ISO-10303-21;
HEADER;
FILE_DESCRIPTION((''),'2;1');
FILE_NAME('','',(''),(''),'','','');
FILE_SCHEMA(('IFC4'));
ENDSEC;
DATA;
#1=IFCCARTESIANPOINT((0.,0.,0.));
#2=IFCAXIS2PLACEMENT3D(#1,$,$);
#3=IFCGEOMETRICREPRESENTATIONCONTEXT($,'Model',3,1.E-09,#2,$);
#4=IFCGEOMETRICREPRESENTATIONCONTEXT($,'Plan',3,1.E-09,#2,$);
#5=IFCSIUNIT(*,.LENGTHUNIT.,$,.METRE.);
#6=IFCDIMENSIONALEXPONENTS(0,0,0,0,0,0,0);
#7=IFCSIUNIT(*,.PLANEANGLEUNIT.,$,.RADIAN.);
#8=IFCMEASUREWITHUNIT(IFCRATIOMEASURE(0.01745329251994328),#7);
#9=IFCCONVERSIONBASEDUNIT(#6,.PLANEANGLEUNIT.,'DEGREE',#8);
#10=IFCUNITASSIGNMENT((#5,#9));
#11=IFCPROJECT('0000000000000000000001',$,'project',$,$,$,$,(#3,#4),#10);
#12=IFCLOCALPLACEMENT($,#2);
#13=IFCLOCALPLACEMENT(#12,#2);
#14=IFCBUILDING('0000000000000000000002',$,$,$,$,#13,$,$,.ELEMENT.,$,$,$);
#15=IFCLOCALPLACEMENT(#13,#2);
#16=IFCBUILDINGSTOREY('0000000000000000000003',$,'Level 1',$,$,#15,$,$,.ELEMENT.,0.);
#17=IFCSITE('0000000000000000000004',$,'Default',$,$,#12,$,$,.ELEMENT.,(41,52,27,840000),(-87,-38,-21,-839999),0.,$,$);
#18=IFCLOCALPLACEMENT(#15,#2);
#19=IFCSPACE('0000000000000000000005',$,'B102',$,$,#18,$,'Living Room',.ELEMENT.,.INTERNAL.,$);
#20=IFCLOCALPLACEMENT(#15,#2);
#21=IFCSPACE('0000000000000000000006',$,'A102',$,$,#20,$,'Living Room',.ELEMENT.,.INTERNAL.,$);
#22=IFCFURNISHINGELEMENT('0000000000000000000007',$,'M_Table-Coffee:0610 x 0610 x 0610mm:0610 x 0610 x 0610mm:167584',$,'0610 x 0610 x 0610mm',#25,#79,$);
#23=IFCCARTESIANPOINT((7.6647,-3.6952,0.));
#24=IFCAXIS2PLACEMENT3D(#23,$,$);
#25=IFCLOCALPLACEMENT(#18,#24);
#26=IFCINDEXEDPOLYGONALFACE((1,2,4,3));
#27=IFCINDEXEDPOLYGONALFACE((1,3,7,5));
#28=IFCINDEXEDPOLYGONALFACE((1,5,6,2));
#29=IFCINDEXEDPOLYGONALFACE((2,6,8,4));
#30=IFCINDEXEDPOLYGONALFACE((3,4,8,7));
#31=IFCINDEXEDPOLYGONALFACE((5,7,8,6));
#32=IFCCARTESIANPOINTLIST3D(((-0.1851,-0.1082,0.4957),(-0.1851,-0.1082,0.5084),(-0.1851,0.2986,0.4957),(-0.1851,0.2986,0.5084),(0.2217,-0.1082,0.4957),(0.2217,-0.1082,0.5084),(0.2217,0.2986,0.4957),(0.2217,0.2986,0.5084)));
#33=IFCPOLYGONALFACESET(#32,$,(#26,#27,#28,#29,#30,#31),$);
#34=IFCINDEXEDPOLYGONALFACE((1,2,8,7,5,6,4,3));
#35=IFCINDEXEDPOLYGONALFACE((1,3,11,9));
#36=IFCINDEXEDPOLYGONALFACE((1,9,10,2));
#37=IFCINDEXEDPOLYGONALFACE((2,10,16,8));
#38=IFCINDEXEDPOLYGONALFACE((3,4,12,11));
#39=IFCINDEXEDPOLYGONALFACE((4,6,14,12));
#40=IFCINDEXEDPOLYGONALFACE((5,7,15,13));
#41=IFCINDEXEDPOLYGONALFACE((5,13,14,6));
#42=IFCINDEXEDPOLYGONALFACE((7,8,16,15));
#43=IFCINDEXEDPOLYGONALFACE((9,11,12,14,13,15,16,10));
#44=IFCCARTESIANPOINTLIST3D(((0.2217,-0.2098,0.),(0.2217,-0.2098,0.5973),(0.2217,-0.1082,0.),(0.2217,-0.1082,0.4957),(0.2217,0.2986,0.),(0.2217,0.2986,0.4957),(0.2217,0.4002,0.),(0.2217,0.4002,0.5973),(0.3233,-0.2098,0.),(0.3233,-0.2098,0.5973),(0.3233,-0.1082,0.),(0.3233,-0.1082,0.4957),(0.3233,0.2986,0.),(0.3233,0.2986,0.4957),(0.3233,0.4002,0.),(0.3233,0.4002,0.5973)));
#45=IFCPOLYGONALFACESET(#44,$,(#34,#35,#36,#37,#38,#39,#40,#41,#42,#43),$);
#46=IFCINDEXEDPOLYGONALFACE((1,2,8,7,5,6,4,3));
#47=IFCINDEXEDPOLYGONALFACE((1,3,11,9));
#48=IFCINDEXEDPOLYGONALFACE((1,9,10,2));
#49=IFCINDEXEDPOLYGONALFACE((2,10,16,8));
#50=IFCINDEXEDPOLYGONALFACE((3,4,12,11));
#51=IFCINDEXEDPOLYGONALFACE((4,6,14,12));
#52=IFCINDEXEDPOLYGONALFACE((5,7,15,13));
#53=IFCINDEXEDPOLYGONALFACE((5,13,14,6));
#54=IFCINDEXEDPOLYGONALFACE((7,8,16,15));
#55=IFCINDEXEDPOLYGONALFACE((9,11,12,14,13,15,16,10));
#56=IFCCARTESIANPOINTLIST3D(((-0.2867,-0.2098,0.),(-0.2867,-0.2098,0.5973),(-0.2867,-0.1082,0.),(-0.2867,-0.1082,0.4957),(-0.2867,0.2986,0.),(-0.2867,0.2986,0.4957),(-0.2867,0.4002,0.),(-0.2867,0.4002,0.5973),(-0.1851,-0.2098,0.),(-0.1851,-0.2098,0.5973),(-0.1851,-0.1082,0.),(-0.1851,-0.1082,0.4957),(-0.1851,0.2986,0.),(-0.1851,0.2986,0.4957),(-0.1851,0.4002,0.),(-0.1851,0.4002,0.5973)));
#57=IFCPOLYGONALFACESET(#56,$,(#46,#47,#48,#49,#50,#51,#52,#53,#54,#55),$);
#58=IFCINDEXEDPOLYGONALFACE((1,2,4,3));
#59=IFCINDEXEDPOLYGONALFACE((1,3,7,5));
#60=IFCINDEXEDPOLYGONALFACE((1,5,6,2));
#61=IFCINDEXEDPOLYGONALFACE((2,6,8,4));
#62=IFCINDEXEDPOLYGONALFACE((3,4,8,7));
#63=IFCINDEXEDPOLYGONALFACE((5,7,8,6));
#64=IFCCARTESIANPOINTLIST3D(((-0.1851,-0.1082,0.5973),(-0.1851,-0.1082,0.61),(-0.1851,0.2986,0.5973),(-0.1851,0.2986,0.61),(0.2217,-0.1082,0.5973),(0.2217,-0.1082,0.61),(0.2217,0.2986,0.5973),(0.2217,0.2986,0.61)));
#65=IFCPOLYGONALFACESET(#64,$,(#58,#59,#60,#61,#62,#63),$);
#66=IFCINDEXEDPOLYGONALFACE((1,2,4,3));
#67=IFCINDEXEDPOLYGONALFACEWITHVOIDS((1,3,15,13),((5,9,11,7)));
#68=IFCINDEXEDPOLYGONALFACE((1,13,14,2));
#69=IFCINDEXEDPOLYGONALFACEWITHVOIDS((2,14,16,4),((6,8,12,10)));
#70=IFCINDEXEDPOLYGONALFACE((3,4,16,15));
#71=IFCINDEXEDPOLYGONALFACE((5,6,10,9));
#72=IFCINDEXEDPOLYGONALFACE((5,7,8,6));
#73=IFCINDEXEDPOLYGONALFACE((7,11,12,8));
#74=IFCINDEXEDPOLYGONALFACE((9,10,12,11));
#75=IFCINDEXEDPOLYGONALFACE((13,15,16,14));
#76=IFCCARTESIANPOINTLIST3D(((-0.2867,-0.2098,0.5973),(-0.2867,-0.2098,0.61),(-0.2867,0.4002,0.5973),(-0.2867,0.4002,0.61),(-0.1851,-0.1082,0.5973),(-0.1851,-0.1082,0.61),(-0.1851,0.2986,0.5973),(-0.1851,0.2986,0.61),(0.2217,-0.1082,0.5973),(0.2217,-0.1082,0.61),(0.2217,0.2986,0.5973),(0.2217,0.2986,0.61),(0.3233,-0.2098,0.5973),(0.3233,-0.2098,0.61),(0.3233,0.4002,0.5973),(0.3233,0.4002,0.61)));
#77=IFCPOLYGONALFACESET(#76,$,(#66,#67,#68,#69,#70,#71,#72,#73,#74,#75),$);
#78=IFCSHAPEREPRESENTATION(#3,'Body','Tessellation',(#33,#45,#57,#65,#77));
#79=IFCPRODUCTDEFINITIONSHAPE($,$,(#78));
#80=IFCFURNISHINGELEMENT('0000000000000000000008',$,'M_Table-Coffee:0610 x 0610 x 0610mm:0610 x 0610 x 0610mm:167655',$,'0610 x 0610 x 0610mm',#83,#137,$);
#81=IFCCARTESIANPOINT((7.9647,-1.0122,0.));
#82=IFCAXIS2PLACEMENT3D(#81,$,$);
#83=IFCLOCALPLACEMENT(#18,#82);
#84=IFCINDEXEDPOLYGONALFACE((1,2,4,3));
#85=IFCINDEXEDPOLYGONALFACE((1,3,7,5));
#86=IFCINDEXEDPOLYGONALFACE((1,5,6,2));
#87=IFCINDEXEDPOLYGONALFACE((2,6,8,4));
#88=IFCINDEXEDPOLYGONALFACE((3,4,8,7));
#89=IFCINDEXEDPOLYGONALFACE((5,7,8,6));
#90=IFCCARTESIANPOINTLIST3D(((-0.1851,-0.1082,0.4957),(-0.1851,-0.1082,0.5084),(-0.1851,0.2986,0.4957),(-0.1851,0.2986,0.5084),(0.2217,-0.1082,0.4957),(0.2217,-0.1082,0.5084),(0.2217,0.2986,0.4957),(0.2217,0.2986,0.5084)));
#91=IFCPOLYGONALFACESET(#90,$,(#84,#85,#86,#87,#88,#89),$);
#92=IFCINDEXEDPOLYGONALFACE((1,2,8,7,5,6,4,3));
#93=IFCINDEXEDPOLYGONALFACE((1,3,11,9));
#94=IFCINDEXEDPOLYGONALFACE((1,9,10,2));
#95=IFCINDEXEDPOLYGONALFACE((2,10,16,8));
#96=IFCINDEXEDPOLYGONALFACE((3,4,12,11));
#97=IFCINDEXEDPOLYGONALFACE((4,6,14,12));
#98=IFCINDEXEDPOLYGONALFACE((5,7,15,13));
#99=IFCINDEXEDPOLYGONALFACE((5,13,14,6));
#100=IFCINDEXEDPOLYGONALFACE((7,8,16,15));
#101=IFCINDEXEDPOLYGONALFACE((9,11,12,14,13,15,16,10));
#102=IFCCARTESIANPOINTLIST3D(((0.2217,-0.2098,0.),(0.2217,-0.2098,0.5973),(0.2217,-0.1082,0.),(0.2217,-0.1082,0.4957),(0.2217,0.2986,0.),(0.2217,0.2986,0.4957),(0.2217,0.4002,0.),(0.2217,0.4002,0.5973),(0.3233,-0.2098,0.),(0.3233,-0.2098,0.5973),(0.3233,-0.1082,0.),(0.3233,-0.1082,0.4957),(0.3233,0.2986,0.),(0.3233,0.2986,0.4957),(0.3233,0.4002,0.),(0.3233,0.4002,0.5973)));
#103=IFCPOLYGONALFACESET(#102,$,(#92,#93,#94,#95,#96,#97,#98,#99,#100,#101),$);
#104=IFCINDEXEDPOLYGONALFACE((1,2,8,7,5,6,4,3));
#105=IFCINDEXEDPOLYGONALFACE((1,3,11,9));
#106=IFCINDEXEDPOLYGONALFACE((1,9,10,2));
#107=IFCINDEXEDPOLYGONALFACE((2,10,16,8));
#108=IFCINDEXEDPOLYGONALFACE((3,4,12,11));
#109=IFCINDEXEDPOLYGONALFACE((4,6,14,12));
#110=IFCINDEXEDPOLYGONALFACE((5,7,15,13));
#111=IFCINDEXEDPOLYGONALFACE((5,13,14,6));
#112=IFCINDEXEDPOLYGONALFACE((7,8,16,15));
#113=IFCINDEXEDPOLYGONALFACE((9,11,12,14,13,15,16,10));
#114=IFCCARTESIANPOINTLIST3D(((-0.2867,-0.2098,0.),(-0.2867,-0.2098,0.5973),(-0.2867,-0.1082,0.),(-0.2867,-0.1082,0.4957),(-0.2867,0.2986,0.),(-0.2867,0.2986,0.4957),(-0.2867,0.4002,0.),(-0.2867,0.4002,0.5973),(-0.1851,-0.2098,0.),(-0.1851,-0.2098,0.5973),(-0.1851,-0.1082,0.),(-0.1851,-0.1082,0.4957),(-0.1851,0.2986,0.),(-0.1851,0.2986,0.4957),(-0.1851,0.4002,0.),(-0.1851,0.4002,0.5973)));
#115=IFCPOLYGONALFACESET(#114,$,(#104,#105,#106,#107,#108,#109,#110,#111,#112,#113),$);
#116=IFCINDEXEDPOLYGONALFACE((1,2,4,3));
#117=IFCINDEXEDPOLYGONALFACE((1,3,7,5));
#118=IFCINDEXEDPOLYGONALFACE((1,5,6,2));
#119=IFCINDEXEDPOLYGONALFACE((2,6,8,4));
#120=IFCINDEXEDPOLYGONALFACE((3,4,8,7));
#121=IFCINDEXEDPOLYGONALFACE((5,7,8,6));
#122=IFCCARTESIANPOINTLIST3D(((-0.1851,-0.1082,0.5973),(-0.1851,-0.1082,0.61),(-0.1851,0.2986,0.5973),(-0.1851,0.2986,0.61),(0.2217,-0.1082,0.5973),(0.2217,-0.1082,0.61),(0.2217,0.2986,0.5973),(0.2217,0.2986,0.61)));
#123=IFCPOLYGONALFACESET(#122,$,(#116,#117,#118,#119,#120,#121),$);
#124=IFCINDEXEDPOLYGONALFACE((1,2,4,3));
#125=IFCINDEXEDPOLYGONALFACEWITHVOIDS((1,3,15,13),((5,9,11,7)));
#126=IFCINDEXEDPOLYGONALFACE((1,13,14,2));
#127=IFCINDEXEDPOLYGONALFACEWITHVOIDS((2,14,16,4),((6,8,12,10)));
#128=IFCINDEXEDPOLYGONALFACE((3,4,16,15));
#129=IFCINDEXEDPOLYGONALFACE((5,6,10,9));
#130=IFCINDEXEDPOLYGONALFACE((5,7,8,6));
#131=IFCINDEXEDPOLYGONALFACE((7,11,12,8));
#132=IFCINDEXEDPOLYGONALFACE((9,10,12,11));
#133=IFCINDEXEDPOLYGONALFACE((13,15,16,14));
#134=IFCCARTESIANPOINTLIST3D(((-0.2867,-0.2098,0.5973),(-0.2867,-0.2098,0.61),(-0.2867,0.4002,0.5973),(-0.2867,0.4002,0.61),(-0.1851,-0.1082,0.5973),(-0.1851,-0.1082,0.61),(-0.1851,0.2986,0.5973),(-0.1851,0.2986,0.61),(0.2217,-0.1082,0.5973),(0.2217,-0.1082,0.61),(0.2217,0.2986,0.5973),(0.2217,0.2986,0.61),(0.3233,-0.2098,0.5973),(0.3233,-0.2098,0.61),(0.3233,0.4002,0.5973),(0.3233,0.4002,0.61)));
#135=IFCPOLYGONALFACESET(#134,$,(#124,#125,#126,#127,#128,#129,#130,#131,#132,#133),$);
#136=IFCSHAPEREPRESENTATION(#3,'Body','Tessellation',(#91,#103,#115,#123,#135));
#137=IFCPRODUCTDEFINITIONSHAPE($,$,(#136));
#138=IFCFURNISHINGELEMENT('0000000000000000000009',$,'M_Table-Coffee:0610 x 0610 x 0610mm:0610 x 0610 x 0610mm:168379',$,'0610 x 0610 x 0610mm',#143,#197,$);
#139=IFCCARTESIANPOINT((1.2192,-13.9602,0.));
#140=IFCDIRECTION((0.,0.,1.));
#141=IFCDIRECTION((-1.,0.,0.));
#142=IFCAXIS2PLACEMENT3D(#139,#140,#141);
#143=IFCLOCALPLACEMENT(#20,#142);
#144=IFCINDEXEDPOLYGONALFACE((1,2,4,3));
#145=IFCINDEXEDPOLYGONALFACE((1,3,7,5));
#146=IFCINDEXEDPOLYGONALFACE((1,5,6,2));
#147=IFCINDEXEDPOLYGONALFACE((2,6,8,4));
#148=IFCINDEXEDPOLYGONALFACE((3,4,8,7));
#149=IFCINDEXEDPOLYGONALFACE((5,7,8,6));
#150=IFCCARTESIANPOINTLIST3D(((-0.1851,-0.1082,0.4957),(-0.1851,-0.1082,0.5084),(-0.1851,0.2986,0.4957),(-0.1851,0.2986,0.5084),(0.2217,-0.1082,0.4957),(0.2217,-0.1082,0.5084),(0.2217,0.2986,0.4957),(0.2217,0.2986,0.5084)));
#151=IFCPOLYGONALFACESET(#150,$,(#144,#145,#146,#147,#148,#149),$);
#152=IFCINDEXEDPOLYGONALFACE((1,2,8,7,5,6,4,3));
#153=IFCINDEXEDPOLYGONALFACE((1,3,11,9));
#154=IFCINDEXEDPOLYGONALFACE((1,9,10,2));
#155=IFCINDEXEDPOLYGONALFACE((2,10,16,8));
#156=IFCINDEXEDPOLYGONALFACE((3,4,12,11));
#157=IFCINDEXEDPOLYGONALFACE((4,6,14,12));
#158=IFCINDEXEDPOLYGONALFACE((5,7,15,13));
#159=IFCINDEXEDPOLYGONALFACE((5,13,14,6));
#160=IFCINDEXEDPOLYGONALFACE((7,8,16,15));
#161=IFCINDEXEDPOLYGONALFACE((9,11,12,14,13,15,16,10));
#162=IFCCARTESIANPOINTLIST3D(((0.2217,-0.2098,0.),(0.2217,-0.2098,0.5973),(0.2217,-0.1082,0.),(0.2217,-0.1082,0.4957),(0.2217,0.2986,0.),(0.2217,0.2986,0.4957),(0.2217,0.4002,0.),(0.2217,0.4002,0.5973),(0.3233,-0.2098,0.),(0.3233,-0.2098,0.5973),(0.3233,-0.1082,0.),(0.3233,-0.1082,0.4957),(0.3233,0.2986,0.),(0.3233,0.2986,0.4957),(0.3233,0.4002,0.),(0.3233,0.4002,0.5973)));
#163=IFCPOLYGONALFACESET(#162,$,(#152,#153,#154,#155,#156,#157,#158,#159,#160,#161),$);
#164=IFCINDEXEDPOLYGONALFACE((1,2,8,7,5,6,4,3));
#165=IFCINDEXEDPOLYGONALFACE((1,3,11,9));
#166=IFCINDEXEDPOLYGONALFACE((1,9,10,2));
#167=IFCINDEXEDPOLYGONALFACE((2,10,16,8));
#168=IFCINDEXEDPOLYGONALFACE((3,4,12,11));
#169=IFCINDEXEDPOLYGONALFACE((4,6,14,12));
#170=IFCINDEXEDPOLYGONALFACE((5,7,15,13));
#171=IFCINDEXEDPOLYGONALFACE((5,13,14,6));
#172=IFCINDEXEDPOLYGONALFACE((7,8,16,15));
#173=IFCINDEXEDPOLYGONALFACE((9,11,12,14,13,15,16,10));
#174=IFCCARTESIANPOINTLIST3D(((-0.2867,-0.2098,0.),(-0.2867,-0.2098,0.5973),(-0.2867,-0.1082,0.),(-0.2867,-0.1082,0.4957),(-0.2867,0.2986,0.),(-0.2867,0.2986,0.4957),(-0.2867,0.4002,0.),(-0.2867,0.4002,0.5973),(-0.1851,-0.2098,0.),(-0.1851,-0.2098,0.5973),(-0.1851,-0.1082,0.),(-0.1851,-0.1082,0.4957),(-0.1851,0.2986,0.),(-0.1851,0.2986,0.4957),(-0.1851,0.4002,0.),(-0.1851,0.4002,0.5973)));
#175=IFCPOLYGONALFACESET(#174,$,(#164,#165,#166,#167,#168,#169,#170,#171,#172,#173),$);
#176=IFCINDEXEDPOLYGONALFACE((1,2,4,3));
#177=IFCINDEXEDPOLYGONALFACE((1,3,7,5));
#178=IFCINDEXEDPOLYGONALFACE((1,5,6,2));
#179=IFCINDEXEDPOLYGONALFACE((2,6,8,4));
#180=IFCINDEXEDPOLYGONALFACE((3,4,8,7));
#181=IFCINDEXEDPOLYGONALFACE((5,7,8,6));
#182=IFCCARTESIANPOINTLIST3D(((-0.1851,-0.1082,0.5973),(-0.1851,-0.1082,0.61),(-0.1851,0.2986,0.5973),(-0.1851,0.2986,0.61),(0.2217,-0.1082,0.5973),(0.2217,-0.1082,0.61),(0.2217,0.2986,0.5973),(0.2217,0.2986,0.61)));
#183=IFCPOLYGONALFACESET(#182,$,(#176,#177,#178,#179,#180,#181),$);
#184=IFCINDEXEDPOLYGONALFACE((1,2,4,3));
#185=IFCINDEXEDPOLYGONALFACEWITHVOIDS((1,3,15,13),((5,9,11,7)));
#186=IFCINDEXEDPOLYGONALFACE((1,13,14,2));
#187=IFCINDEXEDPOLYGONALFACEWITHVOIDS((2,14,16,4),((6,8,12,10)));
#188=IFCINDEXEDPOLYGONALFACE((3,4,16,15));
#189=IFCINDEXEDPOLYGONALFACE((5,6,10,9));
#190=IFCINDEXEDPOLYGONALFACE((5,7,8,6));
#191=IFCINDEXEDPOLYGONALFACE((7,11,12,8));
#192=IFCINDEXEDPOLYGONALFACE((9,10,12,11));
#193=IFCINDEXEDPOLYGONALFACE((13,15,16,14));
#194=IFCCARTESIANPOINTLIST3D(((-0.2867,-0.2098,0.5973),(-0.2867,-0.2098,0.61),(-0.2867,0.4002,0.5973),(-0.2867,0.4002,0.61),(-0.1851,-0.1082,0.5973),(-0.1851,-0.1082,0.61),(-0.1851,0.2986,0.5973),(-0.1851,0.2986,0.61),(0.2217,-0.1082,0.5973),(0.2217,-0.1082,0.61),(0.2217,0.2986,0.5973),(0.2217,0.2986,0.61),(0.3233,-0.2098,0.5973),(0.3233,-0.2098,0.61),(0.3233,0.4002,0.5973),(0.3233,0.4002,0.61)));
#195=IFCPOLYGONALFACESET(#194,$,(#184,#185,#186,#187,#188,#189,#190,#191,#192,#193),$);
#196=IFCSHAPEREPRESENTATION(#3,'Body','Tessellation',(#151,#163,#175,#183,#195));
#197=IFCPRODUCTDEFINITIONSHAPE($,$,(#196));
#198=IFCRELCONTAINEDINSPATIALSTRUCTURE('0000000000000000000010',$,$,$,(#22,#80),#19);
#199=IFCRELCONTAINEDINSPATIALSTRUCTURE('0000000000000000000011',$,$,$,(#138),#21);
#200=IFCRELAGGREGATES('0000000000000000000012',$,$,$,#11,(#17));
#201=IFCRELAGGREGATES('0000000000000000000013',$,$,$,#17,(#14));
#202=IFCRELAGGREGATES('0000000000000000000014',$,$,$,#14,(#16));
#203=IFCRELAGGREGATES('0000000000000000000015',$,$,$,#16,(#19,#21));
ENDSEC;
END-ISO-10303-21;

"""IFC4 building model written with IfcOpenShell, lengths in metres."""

from ifc_helpers import new_model, entity, si_unit, converted_unit, frame, origin, origin_2d_with_axis, place, context, project, spatial, polyline, rectangle, outline, extrude, source, transform, mapped, element, save


model = new_model("IFC4")

# Units and contexts
model_context = context("Model", 3, precision=1e-09, world=origin())
plan_context = context("Plan", 3, precision=1e-09, world=origin())
ifc_project = project(units=[si_unit("LENGTHUNIT", "METRE"), converted_unit("PLANEANGLEUNIT", "DEGREE", entity("IfcRatioMeasure", 0.01745329251994328), si_unit("PLANEANGLEUNIT", "RADIAN"), dimensions=[0, 0, 0, 0, 0, 0, 0])], contexts=[model_context, plan_context])

# Site, building, storey
site_placement = place(None, origin())
site = spatial("IfcSite", under=ifc_project, at=site_placement, Name="Default", CompositionType="ELEMENT", RefLatitude=(41, 52, 27, 840000), RefLongitude=(-87, -38, -21, -839999), RefElevation=0.0)
building_placement = place(site_placement, origin())
building = spatial("IfcBuilding", under=site, at=building_placement, CompositionType="ELEMENT")
storey_placement = place(building_placement, origin())
storey = spatial("IfcBuildingStorey", under=building, at=storey_placement, Name="Level 1", CompositionType="ELEMENT", Elevation=0.0)

# Shared definitions
space_1_placement = place(storey_placement, origin())
space_1 = spatial("IfcSpace", under=storey, at=space_1_placement, Name="B102", LongName="Living Room", CompositionType="ELEMENT", PredefinedType="INTERNAL")

# Furnishing elements
shared_shape_1 = source(origin(), model_context, "Body", "SweptSolid", [
    extrude(rectangle(XDim=0.4068, YDim=0.4068, at=origin_2d_with_axis()), frame((0.0183, 0.0952, 0.4957), z_axis=(0.0, 0.0, 1.0), x_axis=(-1.0, 0.0, 0.0)), (0.0, 0.0, 1.0), 0.0127),
    extrude(outline(polyline([(-0.2732, -0.305), (0.324, -0.305), (0.324, 0.305), (-0.2732, 0.305), (-0.2732, 0.2034), (0.2225, 0.2034), (0.2225, -0.2034), (-0.2732, -0.2034), (-0.2732, -0.305)])), frame((0.2217, 0.0952, 0.2732), z_axis=(1.0, 0.0, 0.0), x_axis=(0.0, 0.0, 1.0)), (0.0, 0.0, 1.0), 0.1016),
    extrude(outline(polyline([(-0.305, -0.3241), (0.305, -0.3241), (0.305, 0.2733), (0.2034, 0.2733), (0.2034, -0.2224), (-0.2034, -0.2224), (-0.2034, 0.2733), (-0.305, 0.2733), (-0.305, -0.3241)])), frame((-0.2867, 0.0952, 0.2733), z_axis=(1.0, 0.0, 0.0), x_axis=(0.0, -1.0, 0.0)), (0.0, 0.0, 1.0), 0.1016),
    extrude(rectangle(XDim=0.4068, YDim=0.4068, at=origin_2d_with_axis()), frame((0.0183, 0.0952, 0.5973), z_axis=(0.0, 0.0, 1.0), x_axis=(-1.0, 0.0, 0.0)), (0.0, 0.0, 1.0), 0.0127),
    extrude(outline(polyline([(-0.305, -0.305), (0.305, -0.305), (0.305, 0.305), (-0.305, 0.305), (-0.305, -0.305)]), holes=[polyline([(-0.2034, -0.2034), (-0.2034, 0.2034), (0.2034, 0.2034), (0.2034, -0.2034), (-0.2034, -0.2034)])]), frame((0.0183, 0.0952, 0.5973), z_axis=(0.0, 0.0, 1.0), x_axis=(-1.0, 0.0, 0.0)), (0.0, 0.0, 1.0), 0.0127),
])
for number, where, name in (
    (1, (7.6647, -3.6952, 0.0), "M_Table-Coffee:0610 x 0610 x 0610mm:0610 x 0610 x 0610mm:167584"),
    (2, (7.9647, -1.0122, 0.0), "M_Table-Coffee:0610 x 0610 x 0610mm:0610 x 0610 x 0610mm:167655"),
):
    element("IfcFurnishingElement", number, at=place(space_1_placement, frame(where)), inside=space_1, Name=name, ObjectType="0610 x 0610 x 0610mm", context=model_context, shape_type="MappedRepresentation", body=[
        mapped(shared_shape_1, transform((0.0, 0.0, 0.0), scale=1.0)),
    ])

# Shared definitions
space_2_placement = place(storey_placement, origin())
space_2 = spatial("IfcSpace", under=storey, at=space_2_placement, Name="A102", LongName="Living Room", CompositionType="ELEMENT", PredefinedType="INTERNAL")

# Furnishing element
for number, where, z_axis, x_axis, name in (
    (3, (1.2192, -13.9602, 0.0), (0.0, 0.0, 1.0), (-1.0, 0.0, 0.0), "M_Table-Coffee:0610 x 0610 x 0610mm:0610 x 0610 x 0610mm:168379"),
):
    element("IfcFurnishingElement", number, at=place(space_2_placement, frame(where, z_axis=z_axis, x_axis=x_axis)), inside=space_2, Name=name, ObjectType="0610 x 0610 x 0610mm", context=model_context, shape_type="MappedRepresentation", body=[
        mapped(shared_shape_1, transform((0.0, 0.0, 0.0), scale=1.0)),
    ])

save(model, "model.ifc")
